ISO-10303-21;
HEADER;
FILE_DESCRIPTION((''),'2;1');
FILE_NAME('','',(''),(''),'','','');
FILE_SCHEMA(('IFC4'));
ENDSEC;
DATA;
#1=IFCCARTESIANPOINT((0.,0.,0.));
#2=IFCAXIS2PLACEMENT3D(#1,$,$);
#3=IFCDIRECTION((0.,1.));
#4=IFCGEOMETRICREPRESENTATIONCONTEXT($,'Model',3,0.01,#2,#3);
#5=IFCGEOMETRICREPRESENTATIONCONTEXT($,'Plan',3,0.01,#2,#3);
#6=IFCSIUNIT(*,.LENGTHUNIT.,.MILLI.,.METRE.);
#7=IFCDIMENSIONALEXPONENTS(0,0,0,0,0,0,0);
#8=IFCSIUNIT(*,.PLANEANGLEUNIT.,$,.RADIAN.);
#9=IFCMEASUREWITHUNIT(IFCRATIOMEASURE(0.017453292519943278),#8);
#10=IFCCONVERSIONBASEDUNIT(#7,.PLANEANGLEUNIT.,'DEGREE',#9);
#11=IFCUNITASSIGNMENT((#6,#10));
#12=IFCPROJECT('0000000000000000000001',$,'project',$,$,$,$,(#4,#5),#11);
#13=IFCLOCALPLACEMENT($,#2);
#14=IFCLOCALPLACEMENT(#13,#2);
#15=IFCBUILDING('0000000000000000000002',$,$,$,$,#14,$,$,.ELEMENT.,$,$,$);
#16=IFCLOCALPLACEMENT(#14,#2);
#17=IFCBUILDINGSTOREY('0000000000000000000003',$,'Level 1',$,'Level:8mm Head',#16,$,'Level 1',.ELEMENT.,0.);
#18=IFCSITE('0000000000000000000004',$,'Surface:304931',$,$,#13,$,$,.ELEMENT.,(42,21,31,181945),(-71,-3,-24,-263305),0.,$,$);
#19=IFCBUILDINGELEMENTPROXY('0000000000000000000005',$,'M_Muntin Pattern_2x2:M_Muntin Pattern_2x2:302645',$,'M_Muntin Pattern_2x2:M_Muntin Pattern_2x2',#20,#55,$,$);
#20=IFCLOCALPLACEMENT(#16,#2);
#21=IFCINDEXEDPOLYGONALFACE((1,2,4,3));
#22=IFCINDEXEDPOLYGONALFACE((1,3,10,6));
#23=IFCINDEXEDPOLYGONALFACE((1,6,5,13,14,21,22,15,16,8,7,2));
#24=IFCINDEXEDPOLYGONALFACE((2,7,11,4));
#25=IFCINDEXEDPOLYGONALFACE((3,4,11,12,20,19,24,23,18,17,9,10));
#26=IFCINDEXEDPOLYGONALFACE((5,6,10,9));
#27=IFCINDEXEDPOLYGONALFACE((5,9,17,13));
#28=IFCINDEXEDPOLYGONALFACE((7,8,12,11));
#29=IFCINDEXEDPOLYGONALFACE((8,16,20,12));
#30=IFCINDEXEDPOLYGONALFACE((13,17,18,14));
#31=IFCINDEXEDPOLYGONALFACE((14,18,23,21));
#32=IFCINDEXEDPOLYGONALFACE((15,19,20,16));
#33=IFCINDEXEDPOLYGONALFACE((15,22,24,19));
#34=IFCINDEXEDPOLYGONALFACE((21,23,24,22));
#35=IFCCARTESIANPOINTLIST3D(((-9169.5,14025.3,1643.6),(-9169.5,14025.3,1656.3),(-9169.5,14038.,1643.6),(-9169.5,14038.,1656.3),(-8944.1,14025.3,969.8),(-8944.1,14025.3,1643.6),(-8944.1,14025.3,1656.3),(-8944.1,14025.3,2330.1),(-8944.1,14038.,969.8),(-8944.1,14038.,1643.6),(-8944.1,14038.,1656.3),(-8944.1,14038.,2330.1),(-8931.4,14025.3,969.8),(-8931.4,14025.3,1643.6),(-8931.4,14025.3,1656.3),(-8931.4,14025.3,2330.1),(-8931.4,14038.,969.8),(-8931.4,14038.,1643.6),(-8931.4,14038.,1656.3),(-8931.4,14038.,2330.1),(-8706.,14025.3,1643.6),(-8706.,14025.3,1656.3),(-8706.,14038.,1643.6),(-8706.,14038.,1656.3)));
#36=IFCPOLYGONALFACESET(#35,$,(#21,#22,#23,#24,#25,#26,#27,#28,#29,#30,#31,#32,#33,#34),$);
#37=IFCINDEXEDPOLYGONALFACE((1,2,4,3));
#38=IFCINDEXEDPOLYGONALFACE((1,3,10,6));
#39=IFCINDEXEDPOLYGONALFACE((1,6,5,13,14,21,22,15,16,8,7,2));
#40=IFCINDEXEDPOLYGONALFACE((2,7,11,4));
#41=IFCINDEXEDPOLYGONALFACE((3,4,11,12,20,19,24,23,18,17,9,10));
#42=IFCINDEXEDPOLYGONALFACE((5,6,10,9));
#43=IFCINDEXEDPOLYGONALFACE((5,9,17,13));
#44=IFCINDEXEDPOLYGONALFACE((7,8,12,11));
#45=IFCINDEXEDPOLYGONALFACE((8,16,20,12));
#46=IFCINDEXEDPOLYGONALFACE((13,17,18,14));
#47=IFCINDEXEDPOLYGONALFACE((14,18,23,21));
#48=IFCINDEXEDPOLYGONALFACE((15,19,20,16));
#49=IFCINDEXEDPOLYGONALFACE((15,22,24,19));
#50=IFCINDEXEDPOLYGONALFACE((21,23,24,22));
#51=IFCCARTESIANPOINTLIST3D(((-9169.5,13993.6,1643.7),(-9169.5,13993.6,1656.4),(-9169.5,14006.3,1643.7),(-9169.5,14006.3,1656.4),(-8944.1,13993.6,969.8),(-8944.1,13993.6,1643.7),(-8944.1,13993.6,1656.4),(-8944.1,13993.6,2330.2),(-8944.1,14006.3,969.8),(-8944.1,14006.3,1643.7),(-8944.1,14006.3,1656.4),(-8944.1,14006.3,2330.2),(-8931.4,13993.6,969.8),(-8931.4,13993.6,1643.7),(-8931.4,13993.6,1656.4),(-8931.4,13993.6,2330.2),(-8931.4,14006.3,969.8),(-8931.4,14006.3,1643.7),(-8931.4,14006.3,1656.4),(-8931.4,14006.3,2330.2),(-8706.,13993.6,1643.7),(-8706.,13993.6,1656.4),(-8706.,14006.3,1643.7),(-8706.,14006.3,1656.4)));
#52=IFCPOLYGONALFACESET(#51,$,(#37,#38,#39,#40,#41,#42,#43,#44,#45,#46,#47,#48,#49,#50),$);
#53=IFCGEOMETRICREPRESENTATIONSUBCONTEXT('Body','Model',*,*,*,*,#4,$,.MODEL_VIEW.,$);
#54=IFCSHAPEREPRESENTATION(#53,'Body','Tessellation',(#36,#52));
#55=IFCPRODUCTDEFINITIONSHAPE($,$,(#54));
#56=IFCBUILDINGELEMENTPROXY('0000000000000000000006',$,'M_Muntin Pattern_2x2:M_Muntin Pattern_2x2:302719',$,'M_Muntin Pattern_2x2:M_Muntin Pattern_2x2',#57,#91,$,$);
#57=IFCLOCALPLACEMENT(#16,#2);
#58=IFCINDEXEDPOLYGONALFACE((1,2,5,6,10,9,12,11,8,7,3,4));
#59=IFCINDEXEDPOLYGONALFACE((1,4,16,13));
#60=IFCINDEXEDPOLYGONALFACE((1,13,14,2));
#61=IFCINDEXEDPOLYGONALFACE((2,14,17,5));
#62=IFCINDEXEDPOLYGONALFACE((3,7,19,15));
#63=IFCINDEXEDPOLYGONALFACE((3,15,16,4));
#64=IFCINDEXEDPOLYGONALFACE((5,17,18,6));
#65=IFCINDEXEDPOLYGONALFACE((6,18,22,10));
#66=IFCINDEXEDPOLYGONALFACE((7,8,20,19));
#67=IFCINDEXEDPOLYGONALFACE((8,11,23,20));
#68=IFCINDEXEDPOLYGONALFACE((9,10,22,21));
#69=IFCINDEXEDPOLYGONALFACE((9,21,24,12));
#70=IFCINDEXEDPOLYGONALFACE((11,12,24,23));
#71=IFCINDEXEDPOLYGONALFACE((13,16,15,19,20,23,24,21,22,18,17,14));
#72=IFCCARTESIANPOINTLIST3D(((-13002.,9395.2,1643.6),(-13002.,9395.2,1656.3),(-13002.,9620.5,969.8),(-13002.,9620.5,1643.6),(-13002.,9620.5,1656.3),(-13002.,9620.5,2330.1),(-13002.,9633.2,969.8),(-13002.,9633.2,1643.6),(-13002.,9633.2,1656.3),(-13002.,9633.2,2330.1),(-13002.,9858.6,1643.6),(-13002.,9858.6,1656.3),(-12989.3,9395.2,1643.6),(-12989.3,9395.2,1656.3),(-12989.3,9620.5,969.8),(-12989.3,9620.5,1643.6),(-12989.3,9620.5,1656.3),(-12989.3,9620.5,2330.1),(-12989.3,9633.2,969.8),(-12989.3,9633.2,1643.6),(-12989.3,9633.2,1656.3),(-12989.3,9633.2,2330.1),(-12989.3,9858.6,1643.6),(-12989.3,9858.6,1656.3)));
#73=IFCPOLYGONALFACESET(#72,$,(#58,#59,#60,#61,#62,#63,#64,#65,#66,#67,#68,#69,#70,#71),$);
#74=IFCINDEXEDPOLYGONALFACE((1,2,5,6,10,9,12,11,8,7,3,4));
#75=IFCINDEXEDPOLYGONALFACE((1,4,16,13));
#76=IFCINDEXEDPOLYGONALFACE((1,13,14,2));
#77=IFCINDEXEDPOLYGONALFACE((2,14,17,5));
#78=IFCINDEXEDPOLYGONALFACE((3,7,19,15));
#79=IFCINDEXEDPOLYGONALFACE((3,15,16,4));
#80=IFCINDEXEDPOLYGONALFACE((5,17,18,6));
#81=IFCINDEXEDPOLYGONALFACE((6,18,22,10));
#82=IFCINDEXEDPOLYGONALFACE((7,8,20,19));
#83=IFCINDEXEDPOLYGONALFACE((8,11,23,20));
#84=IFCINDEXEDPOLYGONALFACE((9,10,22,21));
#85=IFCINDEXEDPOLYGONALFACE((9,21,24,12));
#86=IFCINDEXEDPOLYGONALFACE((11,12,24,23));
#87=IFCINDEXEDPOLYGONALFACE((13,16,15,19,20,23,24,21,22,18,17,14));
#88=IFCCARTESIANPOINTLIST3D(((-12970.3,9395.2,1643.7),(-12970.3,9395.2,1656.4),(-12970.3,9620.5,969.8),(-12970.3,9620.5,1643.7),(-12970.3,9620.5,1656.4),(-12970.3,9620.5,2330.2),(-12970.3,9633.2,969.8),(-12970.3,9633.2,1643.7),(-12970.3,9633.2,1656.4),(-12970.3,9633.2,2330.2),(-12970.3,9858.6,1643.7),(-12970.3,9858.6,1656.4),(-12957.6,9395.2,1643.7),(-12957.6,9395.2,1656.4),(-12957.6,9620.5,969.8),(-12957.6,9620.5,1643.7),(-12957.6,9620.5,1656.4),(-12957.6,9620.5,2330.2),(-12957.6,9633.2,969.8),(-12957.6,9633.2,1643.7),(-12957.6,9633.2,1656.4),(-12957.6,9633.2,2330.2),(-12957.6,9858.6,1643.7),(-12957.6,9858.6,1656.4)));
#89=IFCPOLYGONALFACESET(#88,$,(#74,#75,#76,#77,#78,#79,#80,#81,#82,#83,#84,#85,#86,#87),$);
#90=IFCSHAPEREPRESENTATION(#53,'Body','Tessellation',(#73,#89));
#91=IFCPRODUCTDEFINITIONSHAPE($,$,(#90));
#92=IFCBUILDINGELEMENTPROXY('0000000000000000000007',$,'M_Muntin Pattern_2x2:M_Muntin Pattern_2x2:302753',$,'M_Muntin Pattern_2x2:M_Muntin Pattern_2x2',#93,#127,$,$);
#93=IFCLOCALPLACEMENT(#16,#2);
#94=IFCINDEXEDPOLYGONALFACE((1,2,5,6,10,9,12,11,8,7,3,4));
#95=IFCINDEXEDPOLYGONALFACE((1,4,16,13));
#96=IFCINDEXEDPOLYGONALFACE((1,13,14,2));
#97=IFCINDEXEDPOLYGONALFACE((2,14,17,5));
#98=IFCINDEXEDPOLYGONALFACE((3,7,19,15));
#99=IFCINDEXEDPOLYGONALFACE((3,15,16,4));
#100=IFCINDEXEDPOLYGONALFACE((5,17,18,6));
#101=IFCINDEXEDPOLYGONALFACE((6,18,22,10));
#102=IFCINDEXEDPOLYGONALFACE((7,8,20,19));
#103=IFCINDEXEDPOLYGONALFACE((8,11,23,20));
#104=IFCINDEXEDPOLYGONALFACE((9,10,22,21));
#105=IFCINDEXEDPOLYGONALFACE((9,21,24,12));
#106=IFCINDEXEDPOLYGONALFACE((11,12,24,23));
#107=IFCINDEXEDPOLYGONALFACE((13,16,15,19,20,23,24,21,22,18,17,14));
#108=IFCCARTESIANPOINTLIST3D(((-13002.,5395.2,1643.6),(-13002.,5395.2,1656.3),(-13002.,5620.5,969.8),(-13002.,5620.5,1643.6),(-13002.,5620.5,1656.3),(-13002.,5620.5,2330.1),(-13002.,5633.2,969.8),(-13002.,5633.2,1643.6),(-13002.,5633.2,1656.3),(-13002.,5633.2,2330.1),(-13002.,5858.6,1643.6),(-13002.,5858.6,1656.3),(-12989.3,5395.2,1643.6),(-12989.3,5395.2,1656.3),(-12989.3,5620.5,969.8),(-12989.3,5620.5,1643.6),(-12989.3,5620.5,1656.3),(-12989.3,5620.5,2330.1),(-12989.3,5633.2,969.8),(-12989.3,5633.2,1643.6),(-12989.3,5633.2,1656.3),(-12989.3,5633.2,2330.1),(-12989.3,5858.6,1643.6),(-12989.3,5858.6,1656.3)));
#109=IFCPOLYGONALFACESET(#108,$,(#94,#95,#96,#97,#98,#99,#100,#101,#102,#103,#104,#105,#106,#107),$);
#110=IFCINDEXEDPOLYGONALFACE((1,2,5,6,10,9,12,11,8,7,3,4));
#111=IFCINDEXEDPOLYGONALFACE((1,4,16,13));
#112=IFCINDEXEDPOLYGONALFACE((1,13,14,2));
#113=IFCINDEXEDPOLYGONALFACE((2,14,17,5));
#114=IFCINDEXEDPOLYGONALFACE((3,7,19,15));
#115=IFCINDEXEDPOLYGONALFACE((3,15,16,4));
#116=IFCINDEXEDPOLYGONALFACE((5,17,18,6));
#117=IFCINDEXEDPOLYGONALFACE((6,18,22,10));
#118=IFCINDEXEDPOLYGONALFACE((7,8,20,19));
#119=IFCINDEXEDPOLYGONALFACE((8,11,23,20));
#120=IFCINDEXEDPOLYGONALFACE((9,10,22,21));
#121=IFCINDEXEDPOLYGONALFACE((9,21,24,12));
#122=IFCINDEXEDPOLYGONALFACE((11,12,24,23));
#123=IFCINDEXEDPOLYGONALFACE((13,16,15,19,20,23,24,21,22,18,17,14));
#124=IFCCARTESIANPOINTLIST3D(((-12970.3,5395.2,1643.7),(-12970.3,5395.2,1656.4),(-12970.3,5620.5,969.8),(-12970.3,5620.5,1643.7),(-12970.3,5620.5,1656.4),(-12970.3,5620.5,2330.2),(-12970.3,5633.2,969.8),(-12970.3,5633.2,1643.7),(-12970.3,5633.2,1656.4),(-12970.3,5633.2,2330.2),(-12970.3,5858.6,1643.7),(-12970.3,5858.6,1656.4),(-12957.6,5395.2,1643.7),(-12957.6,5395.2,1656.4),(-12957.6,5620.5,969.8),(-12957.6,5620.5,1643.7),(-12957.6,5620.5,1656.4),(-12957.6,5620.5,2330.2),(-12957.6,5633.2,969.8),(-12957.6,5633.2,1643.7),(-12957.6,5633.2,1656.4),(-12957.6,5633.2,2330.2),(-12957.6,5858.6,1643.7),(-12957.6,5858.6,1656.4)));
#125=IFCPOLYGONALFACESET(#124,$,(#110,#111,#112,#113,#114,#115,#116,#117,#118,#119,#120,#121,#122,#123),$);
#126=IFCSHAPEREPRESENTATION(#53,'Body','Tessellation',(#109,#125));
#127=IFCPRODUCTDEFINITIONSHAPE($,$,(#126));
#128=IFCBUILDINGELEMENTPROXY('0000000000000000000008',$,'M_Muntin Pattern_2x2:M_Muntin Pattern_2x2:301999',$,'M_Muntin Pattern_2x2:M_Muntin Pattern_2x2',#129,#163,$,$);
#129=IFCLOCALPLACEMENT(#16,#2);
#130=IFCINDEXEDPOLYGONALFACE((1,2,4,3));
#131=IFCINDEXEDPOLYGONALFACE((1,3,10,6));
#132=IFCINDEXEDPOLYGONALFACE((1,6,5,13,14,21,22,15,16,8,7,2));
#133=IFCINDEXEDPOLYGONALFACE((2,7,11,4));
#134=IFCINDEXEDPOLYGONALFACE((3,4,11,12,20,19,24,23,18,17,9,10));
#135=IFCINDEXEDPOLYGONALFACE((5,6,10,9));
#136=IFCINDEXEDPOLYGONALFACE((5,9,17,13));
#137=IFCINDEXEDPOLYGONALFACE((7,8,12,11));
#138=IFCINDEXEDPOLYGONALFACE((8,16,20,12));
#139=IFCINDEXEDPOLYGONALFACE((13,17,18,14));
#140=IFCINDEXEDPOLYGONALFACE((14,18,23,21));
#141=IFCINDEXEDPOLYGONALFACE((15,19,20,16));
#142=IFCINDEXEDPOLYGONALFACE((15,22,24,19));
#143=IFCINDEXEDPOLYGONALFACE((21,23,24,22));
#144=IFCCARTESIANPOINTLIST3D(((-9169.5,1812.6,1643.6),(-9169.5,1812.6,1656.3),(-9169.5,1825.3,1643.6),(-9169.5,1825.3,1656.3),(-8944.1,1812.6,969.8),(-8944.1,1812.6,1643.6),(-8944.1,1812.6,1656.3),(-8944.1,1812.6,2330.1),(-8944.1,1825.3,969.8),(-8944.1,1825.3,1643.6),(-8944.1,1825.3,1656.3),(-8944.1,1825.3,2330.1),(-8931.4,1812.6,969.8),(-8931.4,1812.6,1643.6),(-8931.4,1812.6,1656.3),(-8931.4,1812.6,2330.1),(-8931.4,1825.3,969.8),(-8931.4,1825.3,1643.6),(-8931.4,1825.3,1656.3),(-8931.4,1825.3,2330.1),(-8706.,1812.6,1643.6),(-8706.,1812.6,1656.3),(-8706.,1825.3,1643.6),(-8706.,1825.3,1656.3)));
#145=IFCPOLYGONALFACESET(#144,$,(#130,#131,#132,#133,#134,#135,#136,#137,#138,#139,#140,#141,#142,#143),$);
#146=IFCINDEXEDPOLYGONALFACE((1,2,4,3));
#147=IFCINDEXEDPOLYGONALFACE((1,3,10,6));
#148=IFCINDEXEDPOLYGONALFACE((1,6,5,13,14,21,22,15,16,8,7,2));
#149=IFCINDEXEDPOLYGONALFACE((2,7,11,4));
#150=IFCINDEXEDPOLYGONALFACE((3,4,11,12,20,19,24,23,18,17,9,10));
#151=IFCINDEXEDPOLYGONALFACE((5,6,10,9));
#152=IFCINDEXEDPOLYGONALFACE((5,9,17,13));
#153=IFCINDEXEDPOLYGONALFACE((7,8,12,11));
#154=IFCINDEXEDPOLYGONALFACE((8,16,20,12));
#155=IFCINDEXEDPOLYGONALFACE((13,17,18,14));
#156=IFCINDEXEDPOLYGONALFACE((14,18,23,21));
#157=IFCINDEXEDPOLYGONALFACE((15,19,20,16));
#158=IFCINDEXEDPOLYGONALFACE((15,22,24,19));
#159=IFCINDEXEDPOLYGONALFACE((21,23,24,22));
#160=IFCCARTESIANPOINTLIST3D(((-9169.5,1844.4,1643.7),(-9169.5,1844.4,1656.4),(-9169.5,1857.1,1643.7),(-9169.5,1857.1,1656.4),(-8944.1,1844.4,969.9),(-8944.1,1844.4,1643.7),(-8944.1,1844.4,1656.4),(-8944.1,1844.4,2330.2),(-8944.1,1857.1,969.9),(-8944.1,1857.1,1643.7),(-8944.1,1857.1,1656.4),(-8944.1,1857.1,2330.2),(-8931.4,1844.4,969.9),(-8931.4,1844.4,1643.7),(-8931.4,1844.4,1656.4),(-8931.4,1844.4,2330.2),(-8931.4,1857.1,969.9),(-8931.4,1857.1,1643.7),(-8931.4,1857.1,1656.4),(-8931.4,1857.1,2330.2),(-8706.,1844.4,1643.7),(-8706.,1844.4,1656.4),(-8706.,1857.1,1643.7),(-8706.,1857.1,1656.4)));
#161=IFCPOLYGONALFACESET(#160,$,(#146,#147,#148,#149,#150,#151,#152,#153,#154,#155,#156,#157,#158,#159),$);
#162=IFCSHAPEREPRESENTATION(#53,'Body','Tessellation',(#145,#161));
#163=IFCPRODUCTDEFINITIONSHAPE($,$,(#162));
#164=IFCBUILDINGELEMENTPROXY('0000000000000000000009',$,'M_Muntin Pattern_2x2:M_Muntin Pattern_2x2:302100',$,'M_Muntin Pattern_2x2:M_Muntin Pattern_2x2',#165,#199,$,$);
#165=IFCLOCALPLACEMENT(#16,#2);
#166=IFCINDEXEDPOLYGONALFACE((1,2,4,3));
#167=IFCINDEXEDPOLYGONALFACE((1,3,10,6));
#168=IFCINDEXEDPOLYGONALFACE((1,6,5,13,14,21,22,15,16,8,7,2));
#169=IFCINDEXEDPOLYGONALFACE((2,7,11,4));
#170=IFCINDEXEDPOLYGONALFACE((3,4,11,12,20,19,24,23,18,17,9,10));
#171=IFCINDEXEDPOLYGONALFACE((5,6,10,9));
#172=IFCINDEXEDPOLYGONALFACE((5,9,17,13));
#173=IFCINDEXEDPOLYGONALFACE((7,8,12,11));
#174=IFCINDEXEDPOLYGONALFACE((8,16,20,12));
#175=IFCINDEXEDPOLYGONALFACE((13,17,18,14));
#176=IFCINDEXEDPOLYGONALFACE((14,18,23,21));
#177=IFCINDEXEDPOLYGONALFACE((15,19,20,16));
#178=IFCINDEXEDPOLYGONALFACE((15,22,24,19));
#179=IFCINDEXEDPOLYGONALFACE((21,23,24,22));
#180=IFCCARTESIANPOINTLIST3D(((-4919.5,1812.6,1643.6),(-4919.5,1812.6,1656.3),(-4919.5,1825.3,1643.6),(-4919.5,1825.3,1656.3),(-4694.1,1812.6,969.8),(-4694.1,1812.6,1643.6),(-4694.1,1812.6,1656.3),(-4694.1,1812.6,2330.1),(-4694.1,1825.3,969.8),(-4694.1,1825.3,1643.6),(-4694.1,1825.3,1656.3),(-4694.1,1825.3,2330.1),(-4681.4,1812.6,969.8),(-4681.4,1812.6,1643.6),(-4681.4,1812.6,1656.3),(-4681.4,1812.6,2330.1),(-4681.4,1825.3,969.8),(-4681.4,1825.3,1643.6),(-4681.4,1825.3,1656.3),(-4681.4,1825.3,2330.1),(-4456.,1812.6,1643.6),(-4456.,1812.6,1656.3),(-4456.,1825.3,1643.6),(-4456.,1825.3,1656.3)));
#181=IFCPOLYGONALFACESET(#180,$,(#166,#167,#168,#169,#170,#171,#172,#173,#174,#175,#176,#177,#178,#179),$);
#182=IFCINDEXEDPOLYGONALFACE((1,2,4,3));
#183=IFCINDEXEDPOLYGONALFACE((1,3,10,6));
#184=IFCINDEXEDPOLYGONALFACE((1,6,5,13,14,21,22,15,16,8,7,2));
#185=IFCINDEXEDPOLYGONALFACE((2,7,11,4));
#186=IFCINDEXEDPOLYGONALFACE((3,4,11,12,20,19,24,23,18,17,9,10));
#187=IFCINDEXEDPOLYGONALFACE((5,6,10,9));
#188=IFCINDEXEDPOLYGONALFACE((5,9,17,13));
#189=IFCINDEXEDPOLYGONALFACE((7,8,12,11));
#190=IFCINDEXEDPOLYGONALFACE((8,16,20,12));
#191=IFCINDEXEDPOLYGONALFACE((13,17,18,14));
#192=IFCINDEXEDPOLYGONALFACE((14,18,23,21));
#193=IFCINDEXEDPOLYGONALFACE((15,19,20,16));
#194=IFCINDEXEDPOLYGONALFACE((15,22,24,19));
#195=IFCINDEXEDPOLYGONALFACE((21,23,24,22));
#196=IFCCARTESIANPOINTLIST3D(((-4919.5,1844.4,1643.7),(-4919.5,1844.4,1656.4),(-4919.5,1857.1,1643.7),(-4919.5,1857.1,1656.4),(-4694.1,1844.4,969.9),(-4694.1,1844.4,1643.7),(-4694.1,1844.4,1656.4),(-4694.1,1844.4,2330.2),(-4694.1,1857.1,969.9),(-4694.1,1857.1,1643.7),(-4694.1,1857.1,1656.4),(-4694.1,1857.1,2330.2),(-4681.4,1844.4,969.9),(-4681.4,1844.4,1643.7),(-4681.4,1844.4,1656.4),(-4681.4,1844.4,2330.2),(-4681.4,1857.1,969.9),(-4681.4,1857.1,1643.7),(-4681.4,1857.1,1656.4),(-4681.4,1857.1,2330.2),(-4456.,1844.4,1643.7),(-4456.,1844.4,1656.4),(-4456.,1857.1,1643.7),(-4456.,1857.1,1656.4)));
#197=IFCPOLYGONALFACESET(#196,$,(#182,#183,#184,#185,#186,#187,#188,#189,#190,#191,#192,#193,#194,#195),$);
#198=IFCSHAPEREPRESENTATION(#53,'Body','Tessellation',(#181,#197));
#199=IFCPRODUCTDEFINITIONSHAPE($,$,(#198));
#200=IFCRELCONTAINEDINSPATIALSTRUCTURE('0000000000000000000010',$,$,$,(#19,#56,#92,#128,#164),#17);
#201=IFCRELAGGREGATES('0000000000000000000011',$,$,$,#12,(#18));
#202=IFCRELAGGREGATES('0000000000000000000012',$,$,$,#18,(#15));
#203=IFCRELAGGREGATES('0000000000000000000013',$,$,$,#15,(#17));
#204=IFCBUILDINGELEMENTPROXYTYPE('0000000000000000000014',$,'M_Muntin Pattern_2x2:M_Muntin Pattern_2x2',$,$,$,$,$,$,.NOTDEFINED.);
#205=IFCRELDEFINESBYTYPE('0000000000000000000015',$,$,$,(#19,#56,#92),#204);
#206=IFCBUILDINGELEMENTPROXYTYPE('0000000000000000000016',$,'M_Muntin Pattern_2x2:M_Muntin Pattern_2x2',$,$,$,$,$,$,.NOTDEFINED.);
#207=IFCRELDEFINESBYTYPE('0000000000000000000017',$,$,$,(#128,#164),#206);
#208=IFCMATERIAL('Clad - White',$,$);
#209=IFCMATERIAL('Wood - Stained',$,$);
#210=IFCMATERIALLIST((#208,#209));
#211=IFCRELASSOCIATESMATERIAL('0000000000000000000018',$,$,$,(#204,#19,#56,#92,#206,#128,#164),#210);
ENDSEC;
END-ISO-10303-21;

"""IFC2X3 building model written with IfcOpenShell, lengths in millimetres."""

from ifc_helpers import new_model, entity, si_unit, converted_unit, direction, frame, origin, place, context, subcontext, project, spatial, polyline, outline, extrude, source, transform, mapped, material, material_list, type_object, type_shapes, element, save


model = new_model("IFC2X3")

# Units and contexts
model_context = context("Model", 3, precision=0.01, world=origin(), true_north=direction((0.0, 1.0)))
plan_context = context("Plan", 3, precision=0.01, world=origin(), true_north=direction((0.0, 1.0)))
body_context = subcontext(model_context, "Body", "Model", "MODEL_VIEW")
ifc_project = project(units=[si_unit("LENGTHUNIT", "METRE", prefix="MILLI"), converted_unit("PLANEANGLEUNIT", "DEGREE", entity("IfcRatioMeasure", 0.017453292519943278), si_unit("PLANEANGLEUNIT", "RADIAN"), dimensions=[0, 0, 0, 0, 0, 0, 0])], contexts=[model_context, plan_context])

# Site, building, storey
site_placement = place(None, origin())
site = spatial("IfcSite", under=ifc_project, at=site_placement, Name="Surface:304931", CompositionType="ELEMENT", RefLatitude=(42, 21, 31, 181945), RefLongitude=(-71, -3, -24, -263305), RefElevation=0.0)
building_placement = place(site_placement, origin())
building = spatial("IfcBuilding", under=site, at=building_placement, CompositionType="ELEMENT")
storey_placement = place(building_placement, origin())
storey = spatial("IfcBuildingStorey", under=building, at=storey_placement, Name="Level 1", ObjectType="Level:8mm Head", LongName="Level 1", CompositionType="ELEMENT", Elevation=0.0)

# Building element proxies
ifc_material_1 = material(Name="Clad - White")
ifc_material_2 = material(Name="Wood - Stained")
ifc_material_list = material_list([ifc_material_1, ifc_material_2])
building_element_proxy_type_1 = type_object("IfcBuildingElementProxyType", Name="M_Muntin Pattern_2x2:M_Muntin Pattern_2x2", PredefinedType="NOTDEFINED", material=ifc_material_list)
shared_shape_1 = source(origin(), body_context, "Body", "SweptSolid", [
    extrude(outline(polyline([(6.4, -6.4), (680.1, -6.4), (680.1, 6.3), (6.4, 6.3), (6.4, 231.7), (-6.3, 231.7), (-6.3, 6.3), (-680.2, 6.3), (-680.2, -6.4), (-6.3, -6.4), (-6.3, -231.7), (6.4, -231.7), (6.4, -6.4)])), frame((0.0, 9.5, 680.1), z_axis=(0.0, 1.0, 0.0), x_axis=(0.0, 0.0, 1.0)), (0.0, 0.0, 1.0), 12.7),
    extrude(outline(polyline([(6.4, -6.4), (680.2, -6.4), (680.2, 6.3), (6.4, 6.3), (6.4, 231.7), (-6.3, 231.7), (-6.3, 6.3), (-680.2, 6.3), (-680.2, -6.4), (-6.3, -6.4), (-6.3, -231.7), (6.4, -231.7), (6.4, -6.4)])), frame((0.0, -22.2, 680.2), z_axis=(0.0, 1.0, 0.0), x_axis=(0.0, 0.0, 1.0)), (0.0, 0.0, 1.0), 12.7),
])
type_shapes(building_element_proxy_type_1, [shared_shape_1])
for number, where, name in (
    (1, (-8937.7, 14015.8, 969.8), "M_Muntin Pattern_2x2:M_Muntin Pattern_2x2:302645"),
):
    element("IfcBuildingElementProxy", number, at=place(storey_placement, frame(where)), inside=storey, type_object=building_element_proxy_type_1, material=ifc_material_list, Name=name, ObjectType="M_Muntin Pattern_2x2:M_Muntin Pattern_2x2", context=body_context, shape_type="MappedRepresentation", body=[
        mapped(shared_shape_1, transform((0.0, 0.0, 0.0), scale=1.0)),
    ])
for number, where, z_axis, x_axis, name in (
    (2, (-12979.8, 9626.9, 969.8), (0.0, 0.0, 1.0), (0.0, 1.0, 0.0), "M_Muntin Pattern_2x2:M_Muntin Pattern_2x2:302719"),
    (3, (-12979.8, 5626.9, 969.8), (0.0, 0.0, 1.0), (0.0, 1.0, 0.0), "M_Muntin Pattern_2x2:M_Muntin Pattern_2x2:302753"),
):
    element("IfcBuildingElementProxy", number, at=place(storey_placement, frame(where, z_axis=z_axis, x_axis=x_axis)), inside=storey, type_object=building_element_proxy_type_1, material=ifc_material_list, Name=name, ObjectType="M_Muntin Pattern_2x2:M_Muntin Pattern_2x2", context=body_context, shape_type="MappedRepresentation", body=[
        mapped(shared_shape_1, transform((0.0, 0.0, 0.0), scale=1.0)),
    ])
building_element_proxy_type_2 = type_object("IfcBuildingElementProxyType", Name="M_Muntin Pattern_2x2:M_Muntin Pattern_2x2", PredefinedType="NOTDEFINED", material=ifc_material_list)
shared_shape_2 = source(origin(), body_context, "Body", "SweptSolid", [
    extrude(outline(polyline([(6.4, -6.4), (680.1, -6.4), (680.1, 6.3), (6.4, 6.3), (6.4, 231.7), (-6.3, 231.7), (-6.3, 6.3), (-680.2, 6.3), (-680.2, -6.4), (-6.3, -6.4), (-6.3, -231.7), (6.4, -231.7), (6.4, -6.4)])), frame((0.0, -22.2, 680.1), z_axis=(0.0, 1.0, 0.0), x_axis=(0.0, 0.0, 1.0)), (0.0, 0.0, 1.0), 12.7),
    extrude(outline(polyline([(6.4, -6.4), (680.2, -6.4), (680.2, 6.3), (6.4, 6.3), (6.4, 231.7), (-6.3, 231.7), (-6.3, 6.3), (-680.2, 6.3), (-680.2, -6.4), (-6.3, -6.4), (-6.3, -231.7), (6.4, -231.7), (6.4, -6.4)])), frame((0.0, 9.5, 680.2), z_axis=(0.0, 1.0, 0.0), x_axis=(0.0, 0.0, 1.0)), (0.0, 0.0, 1.0), 12.7),
])
type_shapes(building_element_proxy_type_2, [shared_shape_2])
for number, where, name in (
    (4, (-8937.7, 1834.8, 969.9), "M_Muntin Pattern_2x2:M_Muntin Pattern_2x2:301999"),
    (5, (-4687.7, 1834.8, 969.9), "M_Muntin Pattern_2x2:M_Muntin Pattern_2x2:302100"),
):
    element("IfcBuildingElementProxy", number, at=place(storey_placement, frame(where)), inside=storey, type_object=building_element_proxy_type_2, material=ifc_material_list, Name=name, ObjectType="M_Muntin Pattern_2x2:M_Muntin Pattern_2x2", context=body_context, shape_type="MappedRepresentation", body=[
        mapped(shared_shape_2, transform((0.0, 0.0, 0.0), scale=1.0)),
    ])

save(model, "model.ifc")
